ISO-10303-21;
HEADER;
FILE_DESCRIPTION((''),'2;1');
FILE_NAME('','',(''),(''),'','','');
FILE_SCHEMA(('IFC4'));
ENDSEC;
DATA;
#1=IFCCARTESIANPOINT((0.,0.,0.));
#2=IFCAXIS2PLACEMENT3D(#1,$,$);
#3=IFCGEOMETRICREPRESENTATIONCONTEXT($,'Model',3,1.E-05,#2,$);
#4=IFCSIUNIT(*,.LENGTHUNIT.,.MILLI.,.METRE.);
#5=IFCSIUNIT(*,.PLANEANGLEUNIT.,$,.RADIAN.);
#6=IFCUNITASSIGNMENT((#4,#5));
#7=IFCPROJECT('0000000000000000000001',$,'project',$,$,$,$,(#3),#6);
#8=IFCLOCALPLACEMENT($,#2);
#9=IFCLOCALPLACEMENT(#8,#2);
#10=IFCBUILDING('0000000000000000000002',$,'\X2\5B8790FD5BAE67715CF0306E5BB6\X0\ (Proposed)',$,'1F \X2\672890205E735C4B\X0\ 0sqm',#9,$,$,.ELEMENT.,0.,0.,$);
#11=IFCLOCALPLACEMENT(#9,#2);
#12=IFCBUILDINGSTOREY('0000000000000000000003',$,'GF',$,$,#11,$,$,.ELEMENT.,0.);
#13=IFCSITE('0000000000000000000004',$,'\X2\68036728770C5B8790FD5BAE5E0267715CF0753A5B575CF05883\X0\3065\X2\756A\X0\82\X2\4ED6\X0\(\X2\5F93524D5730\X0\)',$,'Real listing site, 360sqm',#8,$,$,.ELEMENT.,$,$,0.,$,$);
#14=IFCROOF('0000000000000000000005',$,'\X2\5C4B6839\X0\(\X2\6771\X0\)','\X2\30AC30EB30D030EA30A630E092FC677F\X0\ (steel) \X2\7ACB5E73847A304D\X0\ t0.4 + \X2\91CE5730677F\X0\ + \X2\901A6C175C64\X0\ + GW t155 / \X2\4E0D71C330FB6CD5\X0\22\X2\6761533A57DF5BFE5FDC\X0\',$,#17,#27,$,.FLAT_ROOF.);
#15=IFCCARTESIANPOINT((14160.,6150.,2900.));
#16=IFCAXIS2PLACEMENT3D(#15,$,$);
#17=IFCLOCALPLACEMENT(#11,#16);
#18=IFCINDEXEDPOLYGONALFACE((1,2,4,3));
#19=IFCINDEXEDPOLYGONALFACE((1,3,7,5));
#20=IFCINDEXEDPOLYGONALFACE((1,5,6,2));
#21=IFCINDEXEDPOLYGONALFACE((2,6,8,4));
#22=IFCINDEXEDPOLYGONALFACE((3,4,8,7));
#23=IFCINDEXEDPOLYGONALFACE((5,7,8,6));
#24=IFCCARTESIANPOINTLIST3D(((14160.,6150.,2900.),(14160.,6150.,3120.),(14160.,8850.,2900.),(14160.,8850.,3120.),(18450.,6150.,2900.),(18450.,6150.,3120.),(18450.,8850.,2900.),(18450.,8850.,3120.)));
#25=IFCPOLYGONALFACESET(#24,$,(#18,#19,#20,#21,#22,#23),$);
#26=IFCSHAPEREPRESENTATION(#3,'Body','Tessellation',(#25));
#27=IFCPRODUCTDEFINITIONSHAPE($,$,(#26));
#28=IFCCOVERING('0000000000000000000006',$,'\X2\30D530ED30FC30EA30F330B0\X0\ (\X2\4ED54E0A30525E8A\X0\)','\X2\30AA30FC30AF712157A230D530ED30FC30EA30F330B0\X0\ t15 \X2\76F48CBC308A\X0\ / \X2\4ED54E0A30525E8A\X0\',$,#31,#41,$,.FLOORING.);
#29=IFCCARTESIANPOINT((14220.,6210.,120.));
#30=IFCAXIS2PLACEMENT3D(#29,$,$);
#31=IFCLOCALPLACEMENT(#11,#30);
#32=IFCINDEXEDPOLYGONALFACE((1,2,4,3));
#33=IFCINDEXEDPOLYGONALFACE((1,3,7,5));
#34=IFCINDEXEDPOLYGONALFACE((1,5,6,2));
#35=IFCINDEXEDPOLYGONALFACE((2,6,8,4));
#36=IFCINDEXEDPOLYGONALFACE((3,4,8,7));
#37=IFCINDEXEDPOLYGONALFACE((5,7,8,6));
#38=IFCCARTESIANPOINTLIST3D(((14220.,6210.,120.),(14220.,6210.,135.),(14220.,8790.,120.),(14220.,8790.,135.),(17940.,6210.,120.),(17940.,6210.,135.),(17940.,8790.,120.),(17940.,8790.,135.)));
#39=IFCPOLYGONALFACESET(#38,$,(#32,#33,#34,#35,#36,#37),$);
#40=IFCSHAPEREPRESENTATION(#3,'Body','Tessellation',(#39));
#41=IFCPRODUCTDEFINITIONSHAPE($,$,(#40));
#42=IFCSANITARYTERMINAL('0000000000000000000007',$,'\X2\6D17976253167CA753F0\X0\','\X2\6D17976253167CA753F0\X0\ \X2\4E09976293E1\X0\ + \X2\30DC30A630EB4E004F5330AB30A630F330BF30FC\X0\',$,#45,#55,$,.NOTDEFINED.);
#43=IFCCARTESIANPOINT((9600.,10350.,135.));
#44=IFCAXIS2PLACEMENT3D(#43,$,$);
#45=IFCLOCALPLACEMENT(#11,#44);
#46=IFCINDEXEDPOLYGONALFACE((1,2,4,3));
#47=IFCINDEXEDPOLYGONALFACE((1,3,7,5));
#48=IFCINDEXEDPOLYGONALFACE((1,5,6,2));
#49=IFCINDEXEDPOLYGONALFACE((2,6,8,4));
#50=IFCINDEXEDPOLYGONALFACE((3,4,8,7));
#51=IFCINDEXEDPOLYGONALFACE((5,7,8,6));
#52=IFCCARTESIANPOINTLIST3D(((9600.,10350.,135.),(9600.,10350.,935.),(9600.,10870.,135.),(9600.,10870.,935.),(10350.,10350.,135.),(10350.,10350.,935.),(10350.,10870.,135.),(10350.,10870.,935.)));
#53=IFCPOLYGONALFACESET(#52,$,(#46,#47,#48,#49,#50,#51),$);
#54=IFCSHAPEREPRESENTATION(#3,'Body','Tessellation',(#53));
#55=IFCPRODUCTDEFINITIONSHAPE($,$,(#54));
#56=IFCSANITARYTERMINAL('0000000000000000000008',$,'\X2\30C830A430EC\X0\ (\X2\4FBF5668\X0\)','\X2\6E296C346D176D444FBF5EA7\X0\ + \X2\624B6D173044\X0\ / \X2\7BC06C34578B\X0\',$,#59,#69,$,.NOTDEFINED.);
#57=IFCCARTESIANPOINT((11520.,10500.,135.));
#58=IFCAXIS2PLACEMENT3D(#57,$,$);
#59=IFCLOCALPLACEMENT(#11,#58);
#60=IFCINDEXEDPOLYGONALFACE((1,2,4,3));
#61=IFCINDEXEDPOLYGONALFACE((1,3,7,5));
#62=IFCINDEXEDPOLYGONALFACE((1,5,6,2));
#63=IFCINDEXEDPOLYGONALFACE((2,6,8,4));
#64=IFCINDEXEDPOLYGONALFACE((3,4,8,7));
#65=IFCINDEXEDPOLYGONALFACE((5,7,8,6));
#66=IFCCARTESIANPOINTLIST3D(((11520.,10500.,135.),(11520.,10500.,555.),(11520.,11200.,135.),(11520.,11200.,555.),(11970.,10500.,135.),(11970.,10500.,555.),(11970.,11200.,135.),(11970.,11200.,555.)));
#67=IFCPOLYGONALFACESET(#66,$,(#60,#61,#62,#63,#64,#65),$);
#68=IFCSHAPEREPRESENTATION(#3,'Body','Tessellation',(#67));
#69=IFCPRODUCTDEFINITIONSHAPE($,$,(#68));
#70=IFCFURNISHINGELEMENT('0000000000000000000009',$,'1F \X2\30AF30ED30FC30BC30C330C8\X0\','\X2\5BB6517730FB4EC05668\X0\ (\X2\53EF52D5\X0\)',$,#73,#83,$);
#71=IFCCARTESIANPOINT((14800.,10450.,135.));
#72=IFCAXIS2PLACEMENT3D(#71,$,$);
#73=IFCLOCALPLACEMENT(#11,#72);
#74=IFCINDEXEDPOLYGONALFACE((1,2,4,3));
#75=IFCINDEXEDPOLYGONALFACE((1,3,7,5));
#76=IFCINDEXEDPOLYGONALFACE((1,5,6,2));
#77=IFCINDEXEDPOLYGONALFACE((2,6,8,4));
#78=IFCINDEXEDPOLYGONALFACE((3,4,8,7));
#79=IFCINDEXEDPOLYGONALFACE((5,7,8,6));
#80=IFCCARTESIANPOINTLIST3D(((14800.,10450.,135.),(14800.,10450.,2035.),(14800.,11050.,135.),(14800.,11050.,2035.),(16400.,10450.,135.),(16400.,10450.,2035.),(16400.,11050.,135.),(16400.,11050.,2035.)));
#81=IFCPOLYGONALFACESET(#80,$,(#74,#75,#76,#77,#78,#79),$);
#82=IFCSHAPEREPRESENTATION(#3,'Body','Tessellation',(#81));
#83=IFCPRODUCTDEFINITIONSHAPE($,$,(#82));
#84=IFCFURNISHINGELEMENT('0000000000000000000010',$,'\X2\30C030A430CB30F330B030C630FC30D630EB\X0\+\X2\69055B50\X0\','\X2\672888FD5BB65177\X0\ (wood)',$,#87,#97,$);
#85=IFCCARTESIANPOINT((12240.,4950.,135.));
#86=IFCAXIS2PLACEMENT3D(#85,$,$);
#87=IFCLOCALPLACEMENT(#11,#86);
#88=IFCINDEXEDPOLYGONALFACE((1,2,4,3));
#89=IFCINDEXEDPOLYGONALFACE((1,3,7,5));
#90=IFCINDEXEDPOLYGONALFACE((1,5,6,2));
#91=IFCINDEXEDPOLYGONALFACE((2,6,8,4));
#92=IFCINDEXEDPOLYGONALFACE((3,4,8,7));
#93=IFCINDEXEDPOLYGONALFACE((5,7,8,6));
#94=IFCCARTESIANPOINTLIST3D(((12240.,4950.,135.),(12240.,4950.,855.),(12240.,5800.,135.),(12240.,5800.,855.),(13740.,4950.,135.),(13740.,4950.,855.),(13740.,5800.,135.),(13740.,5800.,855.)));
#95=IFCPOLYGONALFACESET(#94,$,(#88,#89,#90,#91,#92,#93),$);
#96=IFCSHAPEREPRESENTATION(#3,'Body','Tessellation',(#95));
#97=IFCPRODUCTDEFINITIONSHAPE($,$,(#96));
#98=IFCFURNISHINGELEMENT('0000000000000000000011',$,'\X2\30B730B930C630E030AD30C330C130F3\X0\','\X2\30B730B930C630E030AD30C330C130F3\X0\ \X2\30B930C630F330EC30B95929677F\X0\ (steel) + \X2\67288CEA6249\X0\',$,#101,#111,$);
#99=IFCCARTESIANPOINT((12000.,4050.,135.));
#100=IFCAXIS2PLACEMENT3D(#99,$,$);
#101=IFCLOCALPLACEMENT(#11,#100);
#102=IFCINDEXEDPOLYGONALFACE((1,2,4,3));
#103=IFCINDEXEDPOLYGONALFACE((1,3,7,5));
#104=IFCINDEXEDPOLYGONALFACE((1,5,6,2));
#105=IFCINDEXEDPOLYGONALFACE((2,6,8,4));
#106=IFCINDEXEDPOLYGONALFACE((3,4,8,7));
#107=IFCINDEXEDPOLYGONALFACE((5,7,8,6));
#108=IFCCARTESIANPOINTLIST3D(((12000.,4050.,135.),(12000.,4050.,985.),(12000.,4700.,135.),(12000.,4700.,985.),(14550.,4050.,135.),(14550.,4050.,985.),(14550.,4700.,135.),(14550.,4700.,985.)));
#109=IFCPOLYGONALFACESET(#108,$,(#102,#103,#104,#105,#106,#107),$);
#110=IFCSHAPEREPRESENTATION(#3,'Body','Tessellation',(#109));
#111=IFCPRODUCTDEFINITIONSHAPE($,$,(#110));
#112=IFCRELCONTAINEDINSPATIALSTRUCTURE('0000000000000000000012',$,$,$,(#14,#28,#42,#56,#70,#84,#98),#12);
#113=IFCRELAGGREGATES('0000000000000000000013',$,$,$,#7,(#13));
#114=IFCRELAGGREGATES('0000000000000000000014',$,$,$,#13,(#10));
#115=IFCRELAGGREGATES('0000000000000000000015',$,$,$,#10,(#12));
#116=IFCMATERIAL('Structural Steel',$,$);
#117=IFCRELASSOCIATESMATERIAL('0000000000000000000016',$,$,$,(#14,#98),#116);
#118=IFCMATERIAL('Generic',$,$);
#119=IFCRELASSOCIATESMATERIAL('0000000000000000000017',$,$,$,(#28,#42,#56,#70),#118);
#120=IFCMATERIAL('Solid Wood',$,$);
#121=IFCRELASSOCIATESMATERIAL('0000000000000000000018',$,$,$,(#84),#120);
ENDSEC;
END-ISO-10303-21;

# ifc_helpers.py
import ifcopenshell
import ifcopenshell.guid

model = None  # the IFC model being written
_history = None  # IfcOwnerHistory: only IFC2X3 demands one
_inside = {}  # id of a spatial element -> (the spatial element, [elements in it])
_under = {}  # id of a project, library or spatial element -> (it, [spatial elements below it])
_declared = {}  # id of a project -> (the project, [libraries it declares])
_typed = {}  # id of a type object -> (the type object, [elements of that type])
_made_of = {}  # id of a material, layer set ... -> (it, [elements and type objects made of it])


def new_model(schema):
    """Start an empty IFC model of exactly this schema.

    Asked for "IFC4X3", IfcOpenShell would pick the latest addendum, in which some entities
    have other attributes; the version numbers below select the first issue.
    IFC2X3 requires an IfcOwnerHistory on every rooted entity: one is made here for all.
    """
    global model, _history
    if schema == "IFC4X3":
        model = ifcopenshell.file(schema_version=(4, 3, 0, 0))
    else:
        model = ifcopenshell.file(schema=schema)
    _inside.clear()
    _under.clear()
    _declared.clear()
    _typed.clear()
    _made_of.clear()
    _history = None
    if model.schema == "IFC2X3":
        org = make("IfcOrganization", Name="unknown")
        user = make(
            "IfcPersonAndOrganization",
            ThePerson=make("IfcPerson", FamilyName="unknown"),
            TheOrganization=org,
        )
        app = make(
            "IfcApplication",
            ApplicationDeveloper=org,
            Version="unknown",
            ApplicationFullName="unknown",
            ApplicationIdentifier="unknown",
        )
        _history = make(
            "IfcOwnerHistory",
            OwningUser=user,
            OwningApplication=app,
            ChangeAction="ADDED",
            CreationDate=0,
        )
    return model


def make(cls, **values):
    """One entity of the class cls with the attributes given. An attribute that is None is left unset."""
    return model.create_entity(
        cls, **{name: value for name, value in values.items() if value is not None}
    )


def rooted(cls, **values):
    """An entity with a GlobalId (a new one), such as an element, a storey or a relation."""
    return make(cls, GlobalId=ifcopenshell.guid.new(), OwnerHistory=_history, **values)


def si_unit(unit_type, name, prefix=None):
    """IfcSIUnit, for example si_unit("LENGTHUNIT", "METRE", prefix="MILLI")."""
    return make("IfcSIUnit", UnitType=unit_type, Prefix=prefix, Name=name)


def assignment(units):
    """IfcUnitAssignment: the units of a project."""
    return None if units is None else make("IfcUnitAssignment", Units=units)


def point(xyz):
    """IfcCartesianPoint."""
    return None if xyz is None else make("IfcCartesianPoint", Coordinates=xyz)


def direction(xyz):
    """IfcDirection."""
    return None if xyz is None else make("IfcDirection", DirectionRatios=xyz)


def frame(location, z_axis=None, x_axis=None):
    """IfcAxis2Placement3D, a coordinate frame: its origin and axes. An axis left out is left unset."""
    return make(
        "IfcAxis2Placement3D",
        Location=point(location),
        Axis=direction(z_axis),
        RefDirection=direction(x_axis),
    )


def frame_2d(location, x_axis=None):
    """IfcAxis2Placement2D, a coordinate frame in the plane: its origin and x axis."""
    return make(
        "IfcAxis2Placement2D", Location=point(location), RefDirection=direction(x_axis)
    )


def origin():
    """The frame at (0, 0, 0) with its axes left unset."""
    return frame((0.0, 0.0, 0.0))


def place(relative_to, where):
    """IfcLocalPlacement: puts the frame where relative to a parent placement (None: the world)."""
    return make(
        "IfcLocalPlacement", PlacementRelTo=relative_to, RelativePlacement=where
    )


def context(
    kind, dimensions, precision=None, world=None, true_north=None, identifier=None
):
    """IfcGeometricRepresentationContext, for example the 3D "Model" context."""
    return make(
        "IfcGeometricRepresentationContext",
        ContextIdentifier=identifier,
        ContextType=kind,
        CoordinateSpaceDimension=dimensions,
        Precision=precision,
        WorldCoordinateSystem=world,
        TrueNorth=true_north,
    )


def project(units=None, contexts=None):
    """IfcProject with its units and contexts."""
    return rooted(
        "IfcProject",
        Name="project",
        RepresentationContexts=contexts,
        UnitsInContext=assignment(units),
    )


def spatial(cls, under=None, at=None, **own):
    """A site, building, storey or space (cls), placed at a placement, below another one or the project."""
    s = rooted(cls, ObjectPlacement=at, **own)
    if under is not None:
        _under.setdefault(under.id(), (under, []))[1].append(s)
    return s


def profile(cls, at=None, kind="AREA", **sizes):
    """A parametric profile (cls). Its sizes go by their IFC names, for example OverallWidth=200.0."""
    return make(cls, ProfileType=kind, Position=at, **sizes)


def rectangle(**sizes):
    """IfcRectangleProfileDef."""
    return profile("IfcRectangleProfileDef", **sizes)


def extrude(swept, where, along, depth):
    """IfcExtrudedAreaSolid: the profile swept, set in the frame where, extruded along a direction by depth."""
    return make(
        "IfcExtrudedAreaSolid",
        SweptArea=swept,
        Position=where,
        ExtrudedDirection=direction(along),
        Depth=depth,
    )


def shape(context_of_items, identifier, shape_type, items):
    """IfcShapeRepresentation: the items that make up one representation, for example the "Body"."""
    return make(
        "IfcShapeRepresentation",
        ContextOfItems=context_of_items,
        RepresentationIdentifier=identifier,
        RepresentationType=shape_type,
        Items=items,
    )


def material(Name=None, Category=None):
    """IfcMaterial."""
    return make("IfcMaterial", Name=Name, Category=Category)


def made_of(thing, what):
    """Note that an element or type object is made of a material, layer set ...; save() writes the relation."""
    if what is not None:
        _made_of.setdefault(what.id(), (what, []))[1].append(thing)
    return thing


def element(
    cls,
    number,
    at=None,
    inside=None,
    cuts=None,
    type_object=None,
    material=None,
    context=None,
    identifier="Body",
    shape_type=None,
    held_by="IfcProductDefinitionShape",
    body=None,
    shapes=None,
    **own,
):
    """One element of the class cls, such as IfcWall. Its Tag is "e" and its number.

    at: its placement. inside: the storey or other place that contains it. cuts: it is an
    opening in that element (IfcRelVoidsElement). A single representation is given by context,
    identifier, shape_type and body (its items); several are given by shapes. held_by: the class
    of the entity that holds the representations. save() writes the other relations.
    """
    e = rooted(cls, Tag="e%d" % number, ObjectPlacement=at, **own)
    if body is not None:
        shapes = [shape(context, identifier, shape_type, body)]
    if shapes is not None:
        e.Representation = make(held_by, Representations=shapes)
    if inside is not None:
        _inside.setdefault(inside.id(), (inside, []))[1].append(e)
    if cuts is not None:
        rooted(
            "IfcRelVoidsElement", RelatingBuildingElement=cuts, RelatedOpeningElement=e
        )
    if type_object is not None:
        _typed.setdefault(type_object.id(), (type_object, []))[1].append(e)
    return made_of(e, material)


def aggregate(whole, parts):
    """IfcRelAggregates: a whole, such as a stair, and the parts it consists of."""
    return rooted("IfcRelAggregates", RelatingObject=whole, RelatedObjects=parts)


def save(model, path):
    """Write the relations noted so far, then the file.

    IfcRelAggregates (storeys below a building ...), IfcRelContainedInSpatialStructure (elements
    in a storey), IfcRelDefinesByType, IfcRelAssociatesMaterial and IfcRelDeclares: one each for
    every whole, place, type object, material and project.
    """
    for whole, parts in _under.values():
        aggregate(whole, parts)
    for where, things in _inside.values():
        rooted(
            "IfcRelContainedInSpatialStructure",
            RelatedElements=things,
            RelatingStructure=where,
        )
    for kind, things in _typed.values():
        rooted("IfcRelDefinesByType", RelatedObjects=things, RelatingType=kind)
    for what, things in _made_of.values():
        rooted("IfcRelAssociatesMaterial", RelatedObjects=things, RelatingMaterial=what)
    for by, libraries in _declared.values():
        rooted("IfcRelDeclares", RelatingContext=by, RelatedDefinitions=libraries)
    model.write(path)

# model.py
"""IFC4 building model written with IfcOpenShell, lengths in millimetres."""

from ifc_helpers import new_model, si_unit, frame, frame_2d, origin, place, context, project, spatial, rectangle, extrude, material, element, save


model = new_model("IFC4")

# Units and contexts
model_context = context("Model", 3, precision=1e-05, world=origin())
ifc_project = project(units=[si_unit("LENGTHUNIT", "METRE", prefix="MILLI"), si_unit("PLANEANGLEUNIT", "RADIAN")], contexts=[model_context])

# Site, building, storey
site_placement = place(None, origin())
site = spatial("IfcSite", under=ifc_project, at=site_placement, Name="栃木県宇都宮市東峰町字峰境3065番82他(従前地)", ObjectType="Real listing site, 360sqm", CompositionType="ELEMENT", RefElevation=0.0)
building_placement = place(site_placement, origin())
building = spatial("IfcBuilding", under=site, at=building_placement, Name="宇都宮東峰の家 (Proposed)", ObjectType="1F 木造平屋 0sqm", CompositionType="ELEMENT", ElevationOfRefHeight=0.0, ElevationOfTerrain=0.0)
storey_placement = place(building_placement, origin())
storey = spatial("IfcBuildingStorey", under=building, at=storey_placement, Name="GF", CompositionType="ELEMENT", Elevation=0.0)

# Shared definitions
ifc_material_1 = material(Name="Solid Wood")

# Roof
ifc_material_2 = material(Name="Structural Steel")
roof_placement = place(storey_placement, frame((14160.0, 6150.0, 2900.0)))
element("IfcRoof", 1, at=roof_placement, inside=storey, material=ifc_material_2, Name="屋根(東)", Description="ガルバリウム鋼板 (steel) 立平葺き t0.4 + 野地板 + 通気層 + GW t155 / 不燃・法22条区域対応", PredefinedType="FLAT_ROOF", context=model_context, shape_type="SweptSolid", body=[
    extrude(rectangle(XDim=4290.0, YDim=2700.0, at=frame_2d((2145.0, 1350.0))), frame((14160.0, 6150.0, 2900.0)), (0.0, 0.0, 1.0), 220.0),
])

# Covering
ifc_material_3 = material(Name="Generic")
covering_placement = place(storey_placement, frame((14220.0, 6210.0, 120.0)))
element("IfcCovering", 2, at=covering_placement, inside=storey, material=ifc_material_3, Name="フローリング (仕上げ床)", Description="オーク無垢フローリング t15 直貼り / 仕上げ床", PredefinedType="FLOORING", context=model_context, shape_type="SweptSolid", body=[
    extrude(rectangle(XDim=3720.0, YDim=2580.0, at=frame_2d((1860.0, 1290.0))), frame((14220.0, 6210.0, 120.0)), (0.0, 0.0, 1.0), 15.0),
])

# Sanitary terminals
sanitary_terminal_1_placement = place(storey_placement, frame((9600.0, 10350.0, 135.0)))
element("IfcSanitaryTerminal", 3, at=sanitary_terminal_1_placement, inside=storey, material=ifc_material_3, Name="洗面化粧台", Description="洗面化粧台 三面鏡 + ボウル一体カウンター", PredefinedType="NOTDEFINED", context=model_context, shape_type="SweptSolid", body=[
    extrude(rectangle(XDim=750.0, YDim=520.0, at=frame_2d((375.0, 260.0))), frame((9600.0, 10350.0, 135.0)), (0.0, 0.0, 1.0), 800.0),
])
sanitary_terminal_2_placement = place(storey_placement, frame((11520.0, 10500.0, 135.0)))
element("IfcSanitaryTerminal", 4, at=sanitary_terminal_2_placement, inside=storey, material=ifc_material_3, Name="トイレ (便器)", Description="温水洗浄便座 + 手洗い / 節水型", PredefinedType="NOTDEFINED", context=model_context, shape_type="SweptSolid", body=[
    extrude(rectangle(XDim=450.0, YDim=700.0, at=frame_2d((225.0, 350.0))), frame((11520.0, 10500.0, 135.0)), (0.0, 0.0, 1.0), 420.0),
])

# Furnishing elements
furnishing_1_placement = place(storey_placement, frame((14800.0, 10450.0, 135.0)))
element("IfcFurnishingElement", 5, at=furnishing_1_placement, inside=storey, material=ifc_material_3, Name="1F クローゼット", Description="家具・什器 (可動)", context=model_context, shape_type="SweptSolid", body=[
    extrude(rectangle(XDim=1600.0, YDim=600.0, at=frame_2d((800.0, 300.0))), frame((14800.0, 10450.0, 135.0)), (0.0, 0.0, 1.0), 1900.0),
])
furnishing_2_placement = place(storey_placement, frame((12240.0, 4950.0, 135.0)))
element("IfcFurnishingElement", 6, at=furnishing_2_placement, inside=storey, material=ifc_material_1, Name="ダイニングテーブル+椅子", Description="木製家具 (wood)", context=model_context, shape_type="SweptSolid", body=[
    extrude(rectangle(XDim=1500.0, YDim=850.0, at=frame_2d((750.0, 425.0))), frame((12240.0, 4950.0, 135.0)), (0.0, 0.0, 1.0), 720.0),
])
furnishing_3_placement = place(storey_placement, frame((12000.0, 4050.0, 135.0)))
element("IfcFurnishingElement", 7, at=furnishing_3_placement, inside=storey, material=ifc_material_2, Name="システムキッチン", Description="システムキッチン ステンレス天板 (steel) + 木質扉", context=model_context, shape_type="SweptSolid", body=[
    extrude(rectangle(XDim=2550.0, YDim=650.0, at=frame_2d((1275.0, 325.0))), frame((12000.0, 4050.0, 135.0)), (0.0, 0.0, 1.0), 850.0),
])

save(model, "model.ifc")
